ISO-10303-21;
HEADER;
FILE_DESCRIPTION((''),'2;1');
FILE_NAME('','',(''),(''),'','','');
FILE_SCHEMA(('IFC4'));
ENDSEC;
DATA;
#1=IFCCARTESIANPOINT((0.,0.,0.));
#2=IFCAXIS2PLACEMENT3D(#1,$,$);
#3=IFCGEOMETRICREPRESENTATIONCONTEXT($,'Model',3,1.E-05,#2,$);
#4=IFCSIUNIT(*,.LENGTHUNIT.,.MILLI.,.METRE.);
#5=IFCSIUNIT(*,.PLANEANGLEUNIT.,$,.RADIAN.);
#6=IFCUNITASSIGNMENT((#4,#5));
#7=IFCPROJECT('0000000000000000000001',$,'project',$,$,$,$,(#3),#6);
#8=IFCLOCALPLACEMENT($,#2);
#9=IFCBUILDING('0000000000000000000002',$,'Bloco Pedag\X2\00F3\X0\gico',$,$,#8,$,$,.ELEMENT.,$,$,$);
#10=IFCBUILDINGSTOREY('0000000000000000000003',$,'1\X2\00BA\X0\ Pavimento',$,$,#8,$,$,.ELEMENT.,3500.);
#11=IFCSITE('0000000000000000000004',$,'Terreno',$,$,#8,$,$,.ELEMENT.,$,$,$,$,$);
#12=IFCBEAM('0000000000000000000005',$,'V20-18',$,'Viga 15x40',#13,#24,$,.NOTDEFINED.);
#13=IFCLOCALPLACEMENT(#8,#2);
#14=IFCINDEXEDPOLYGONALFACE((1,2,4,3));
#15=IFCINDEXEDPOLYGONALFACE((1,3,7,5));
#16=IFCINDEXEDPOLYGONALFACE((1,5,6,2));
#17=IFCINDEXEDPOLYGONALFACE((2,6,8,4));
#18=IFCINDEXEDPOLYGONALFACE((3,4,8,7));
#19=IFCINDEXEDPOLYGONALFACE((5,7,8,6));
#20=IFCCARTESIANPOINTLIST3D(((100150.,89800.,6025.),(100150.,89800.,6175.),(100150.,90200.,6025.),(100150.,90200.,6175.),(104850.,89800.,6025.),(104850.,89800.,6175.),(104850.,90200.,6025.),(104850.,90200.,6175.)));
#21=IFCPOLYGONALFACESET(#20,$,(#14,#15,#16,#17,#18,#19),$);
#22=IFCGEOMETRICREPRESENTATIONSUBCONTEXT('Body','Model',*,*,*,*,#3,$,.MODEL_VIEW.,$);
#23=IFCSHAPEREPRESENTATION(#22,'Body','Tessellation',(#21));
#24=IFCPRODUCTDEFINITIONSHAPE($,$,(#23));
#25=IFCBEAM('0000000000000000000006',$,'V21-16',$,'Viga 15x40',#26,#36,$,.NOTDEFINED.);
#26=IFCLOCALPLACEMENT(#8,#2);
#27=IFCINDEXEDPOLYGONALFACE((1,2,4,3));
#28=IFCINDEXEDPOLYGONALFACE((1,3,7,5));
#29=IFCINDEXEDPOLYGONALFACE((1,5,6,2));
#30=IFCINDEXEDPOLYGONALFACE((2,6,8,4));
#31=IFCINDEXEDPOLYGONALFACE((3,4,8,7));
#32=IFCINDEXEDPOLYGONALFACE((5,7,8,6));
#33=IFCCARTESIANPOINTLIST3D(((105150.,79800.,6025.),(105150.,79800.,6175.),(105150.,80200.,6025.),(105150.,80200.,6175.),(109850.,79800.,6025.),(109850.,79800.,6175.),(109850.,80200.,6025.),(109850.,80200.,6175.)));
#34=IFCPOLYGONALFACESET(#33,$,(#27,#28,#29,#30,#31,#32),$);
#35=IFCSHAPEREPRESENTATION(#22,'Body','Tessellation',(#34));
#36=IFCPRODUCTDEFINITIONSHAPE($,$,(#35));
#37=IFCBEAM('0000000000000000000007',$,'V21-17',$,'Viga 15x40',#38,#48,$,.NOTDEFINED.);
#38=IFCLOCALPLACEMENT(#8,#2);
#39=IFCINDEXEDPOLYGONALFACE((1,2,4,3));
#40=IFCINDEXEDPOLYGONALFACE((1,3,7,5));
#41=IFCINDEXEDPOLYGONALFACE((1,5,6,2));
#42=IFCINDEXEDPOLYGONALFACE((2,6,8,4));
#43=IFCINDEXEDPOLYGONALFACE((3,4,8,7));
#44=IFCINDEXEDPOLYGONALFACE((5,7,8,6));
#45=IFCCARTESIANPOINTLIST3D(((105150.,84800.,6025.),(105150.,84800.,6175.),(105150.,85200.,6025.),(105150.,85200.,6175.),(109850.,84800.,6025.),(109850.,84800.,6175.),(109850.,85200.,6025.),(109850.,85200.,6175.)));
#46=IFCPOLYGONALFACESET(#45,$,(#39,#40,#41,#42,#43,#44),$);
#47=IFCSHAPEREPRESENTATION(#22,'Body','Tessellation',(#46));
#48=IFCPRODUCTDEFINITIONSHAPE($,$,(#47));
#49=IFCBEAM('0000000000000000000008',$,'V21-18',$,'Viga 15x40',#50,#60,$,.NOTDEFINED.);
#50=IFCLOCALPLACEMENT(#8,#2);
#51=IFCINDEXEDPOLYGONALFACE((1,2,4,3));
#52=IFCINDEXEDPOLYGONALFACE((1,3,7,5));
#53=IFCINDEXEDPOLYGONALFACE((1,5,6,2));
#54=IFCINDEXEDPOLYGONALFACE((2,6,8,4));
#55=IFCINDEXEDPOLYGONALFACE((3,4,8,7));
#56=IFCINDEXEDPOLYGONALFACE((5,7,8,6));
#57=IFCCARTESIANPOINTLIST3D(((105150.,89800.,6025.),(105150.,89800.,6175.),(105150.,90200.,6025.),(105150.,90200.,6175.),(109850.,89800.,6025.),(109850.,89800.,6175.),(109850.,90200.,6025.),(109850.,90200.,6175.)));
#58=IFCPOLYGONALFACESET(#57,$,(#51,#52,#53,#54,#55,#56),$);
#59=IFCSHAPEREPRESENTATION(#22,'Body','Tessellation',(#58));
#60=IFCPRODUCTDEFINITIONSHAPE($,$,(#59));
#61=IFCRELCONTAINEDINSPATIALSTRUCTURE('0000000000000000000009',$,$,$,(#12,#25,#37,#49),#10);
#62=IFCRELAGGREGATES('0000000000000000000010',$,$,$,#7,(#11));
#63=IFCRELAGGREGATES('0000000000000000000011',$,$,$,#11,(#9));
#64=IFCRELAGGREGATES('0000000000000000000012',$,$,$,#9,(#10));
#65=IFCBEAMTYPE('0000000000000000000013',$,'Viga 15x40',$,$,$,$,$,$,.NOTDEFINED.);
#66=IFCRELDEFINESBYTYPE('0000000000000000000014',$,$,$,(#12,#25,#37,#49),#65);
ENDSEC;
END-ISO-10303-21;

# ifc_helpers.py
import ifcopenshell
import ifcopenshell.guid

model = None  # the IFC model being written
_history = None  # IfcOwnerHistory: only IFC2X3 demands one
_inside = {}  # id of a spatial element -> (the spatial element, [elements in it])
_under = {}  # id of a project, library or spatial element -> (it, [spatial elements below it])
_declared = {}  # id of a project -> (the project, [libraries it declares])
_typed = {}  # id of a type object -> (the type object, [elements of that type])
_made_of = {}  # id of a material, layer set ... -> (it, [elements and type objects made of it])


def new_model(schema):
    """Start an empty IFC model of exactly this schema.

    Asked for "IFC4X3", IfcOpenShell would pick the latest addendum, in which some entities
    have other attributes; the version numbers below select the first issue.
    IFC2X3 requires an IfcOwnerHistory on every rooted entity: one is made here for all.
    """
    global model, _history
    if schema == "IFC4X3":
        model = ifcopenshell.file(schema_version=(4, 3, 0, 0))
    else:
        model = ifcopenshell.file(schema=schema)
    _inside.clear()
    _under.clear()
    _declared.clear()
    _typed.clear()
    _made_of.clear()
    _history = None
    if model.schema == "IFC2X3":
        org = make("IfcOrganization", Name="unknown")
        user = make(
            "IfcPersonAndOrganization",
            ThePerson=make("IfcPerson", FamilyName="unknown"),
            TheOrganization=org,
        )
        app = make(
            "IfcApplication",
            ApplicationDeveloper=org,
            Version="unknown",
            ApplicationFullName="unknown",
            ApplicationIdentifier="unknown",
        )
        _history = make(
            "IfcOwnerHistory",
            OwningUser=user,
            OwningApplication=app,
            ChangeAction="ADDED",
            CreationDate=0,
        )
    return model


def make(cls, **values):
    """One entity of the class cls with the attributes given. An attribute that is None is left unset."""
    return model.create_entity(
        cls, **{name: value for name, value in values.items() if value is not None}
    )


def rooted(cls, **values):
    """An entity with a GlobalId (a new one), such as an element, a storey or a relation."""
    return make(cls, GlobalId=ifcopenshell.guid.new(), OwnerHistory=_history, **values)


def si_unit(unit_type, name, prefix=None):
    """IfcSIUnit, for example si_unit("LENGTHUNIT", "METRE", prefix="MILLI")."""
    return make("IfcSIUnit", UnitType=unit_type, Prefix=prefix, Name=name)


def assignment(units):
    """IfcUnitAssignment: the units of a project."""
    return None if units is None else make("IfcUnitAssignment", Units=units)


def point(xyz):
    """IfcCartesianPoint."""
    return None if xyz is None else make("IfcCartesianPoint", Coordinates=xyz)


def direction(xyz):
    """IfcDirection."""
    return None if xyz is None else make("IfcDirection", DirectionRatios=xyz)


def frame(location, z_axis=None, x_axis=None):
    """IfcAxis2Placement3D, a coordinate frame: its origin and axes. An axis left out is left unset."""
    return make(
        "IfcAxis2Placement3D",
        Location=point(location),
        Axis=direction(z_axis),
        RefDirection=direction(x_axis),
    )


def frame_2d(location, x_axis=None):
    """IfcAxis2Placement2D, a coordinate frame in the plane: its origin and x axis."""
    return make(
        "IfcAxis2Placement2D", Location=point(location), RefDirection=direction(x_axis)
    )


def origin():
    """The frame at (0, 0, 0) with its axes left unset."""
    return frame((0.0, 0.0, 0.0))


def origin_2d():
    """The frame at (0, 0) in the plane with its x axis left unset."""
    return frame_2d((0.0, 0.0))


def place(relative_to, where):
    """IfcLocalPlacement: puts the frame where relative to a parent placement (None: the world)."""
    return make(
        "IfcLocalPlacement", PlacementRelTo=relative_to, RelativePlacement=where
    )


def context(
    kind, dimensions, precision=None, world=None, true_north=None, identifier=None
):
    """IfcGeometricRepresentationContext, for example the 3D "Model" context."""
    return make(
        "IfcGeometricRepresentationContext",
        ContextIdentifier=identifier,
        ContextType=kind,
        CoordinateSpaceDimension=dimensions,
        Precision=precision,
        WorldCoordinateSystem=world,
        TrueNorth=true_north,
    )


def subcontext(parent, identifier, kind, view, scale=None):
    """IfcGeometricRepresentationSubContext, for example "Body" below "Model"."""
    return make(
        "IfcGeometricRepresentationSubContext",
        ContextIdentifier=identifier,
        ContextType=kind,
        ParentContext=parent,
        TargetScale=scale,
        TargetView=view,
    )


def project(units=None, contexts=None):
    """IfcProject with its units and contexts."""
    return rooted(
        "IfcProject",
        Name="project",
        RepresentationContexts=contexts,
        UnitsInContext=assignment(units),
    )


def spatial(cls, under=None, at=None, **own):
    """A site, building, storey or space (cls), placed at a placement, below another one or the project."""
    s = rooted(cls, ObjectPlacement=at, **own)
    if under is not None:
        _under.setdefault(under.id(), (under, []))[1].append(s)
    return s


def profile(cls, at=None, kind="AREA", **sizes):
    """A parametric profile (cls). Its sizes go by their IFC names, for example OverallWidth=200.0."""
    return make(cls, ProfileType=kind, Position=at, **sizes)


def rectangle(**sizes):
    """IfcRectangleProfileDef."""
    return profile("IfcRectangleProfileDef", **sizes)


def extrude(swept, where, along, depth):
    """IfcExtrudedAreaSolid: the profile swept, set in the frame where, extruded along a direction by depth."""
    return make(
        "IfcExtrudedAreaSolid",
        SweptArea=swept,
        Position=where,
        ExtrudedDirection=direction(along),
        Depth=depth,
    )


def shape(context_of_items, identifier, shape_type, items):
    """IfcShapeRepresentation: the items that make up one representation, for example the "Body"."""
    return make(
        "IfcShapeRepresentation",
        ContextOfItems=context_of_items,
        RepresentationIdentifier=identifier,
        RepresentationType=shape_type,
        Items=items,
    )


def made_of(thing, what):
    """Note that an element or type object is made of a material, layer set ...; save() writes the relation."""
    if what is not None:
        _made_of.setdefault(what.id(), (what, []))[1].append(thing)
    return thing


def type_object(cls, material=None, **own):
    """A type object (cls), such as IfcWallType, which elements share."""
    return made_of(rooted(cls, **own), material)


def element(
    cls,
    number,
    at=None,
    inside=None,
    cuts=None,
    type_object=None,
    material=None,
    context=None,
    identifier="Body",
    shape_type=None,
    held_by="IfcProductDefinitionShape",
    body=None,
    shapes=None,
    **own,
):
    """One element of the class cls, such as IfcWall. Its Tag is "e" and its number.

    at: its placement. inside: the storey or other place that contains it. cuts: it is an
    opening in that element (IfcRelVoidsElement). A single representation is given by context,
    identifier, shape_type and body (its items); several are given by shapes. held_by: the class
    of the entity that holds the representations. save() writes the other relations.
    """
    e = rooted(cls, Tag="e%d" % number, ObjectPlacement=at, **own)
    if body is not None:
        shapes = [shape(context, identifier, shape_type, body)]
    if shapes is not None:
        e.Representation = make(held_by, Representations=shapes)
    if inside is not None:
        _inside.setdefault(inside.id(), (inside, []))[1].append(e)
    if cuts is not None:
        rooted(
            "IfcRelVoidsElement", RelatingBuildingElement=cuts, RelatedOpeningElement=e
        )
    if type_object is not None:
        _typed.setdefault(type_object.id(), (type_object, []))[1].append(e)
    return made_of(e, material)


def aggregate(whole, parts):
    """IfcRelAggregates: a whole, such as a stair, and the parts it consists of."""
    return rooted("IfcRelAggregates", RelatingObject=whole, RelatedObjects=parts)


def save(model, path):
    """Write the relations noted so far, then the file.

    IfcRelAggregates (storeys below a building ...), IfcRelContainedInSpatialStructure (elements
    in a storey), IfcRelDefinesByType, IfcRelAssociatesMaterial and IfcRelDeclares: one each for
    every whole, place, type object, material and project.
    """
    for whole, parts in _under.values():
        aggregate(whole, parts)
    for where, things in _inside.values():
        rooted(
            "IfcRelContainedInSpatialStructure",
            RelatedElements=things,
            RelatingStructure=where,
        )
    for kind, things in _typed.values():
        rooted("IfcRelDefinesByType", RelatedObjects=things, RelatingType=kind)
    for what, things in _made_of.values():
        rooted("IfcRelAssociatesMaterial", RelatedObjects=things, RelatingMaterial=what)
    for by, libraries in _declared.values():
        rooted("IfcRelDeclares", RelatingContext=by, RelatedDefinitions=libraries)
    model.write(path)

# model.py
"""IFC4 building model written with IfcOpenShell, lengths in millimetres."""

from ifc_helpers import new_model, si_unit, frame, origin, origin_2d, place, context, subcontext, project, spatial, rectangle, extrude, type_object, element, save


model = new_model("IFC4")

# Units and contexts
model_context = context("Model", 3, precision=1e-05, world=origin())
body_context = subcontext(model_context, "Body", "Model", "MODEL_VIEW")
ifc_project = project(units=[si_unit("LENGTHUNIT", "METRE", prefix="MILLI"), si_unit("PLANEANGLEUNIT", "RADIAN")], contexts=[model_context])

# Site, building, storey
placement = place(None, origin())
site = spatial("IfcSite", under=ifc_project, at=placement, Name="Terreno", CompositionType="ELEMENT")
building = spatial("IfcBuilding", under=site, at=placement, Name="Bloco Pedagógico", CompositionType="ELEMENT")
storey = spatial("IfcBuildingStorey", under=building, at=placement, Name="1º Pavimento", CompositionType="ELEMENT", Elevation=3500.0)

# Beams
beam_type = type_object("IfcBeamType", Name="Viga 15x40", PredefinedType="NOTDEFINED")
for number, where, z_axis, x_axis, name in (
    (1, (100150.0, 90000.0, 6100.0), (1.0, 0.0, 0.0), (0.0, 1.0, 0.0), "V20-18"),
    (2, (105150.0, 80000.0, 6100.0), (1.0, 0.0, 0.0), (0.0, 1.0, 0.0), "V21-16"),
    (3, (105150.0, 85000.0, 6100.0), (1.0, 0.0, 0.0), (0.0, 1.0, 0.0), "V21-17"),
    (4, (105150.0, 90000.0, 6100.0), (1.0, 0.0, 0.0), (0.0, 1.0, 0.0), "V21-18"),
):
    element("IfcBeam", number, at=place(None, frame(where, z_axis=z_axis, x_axis=x_axis)), inside=storey, type_object=beam_type, Name=name, ObjectType="Viga 15x40", PredefinedType="NOTDEFINED", context=body_context, shape_type="SweptSolid", body=[
        extrude(rectangle(XDim=400.0, YDim=150.0, at=origin_2d()), None, (0.0, 0.0, 1.0), 4700.0),
    ])

save(model, "model.ifc")
